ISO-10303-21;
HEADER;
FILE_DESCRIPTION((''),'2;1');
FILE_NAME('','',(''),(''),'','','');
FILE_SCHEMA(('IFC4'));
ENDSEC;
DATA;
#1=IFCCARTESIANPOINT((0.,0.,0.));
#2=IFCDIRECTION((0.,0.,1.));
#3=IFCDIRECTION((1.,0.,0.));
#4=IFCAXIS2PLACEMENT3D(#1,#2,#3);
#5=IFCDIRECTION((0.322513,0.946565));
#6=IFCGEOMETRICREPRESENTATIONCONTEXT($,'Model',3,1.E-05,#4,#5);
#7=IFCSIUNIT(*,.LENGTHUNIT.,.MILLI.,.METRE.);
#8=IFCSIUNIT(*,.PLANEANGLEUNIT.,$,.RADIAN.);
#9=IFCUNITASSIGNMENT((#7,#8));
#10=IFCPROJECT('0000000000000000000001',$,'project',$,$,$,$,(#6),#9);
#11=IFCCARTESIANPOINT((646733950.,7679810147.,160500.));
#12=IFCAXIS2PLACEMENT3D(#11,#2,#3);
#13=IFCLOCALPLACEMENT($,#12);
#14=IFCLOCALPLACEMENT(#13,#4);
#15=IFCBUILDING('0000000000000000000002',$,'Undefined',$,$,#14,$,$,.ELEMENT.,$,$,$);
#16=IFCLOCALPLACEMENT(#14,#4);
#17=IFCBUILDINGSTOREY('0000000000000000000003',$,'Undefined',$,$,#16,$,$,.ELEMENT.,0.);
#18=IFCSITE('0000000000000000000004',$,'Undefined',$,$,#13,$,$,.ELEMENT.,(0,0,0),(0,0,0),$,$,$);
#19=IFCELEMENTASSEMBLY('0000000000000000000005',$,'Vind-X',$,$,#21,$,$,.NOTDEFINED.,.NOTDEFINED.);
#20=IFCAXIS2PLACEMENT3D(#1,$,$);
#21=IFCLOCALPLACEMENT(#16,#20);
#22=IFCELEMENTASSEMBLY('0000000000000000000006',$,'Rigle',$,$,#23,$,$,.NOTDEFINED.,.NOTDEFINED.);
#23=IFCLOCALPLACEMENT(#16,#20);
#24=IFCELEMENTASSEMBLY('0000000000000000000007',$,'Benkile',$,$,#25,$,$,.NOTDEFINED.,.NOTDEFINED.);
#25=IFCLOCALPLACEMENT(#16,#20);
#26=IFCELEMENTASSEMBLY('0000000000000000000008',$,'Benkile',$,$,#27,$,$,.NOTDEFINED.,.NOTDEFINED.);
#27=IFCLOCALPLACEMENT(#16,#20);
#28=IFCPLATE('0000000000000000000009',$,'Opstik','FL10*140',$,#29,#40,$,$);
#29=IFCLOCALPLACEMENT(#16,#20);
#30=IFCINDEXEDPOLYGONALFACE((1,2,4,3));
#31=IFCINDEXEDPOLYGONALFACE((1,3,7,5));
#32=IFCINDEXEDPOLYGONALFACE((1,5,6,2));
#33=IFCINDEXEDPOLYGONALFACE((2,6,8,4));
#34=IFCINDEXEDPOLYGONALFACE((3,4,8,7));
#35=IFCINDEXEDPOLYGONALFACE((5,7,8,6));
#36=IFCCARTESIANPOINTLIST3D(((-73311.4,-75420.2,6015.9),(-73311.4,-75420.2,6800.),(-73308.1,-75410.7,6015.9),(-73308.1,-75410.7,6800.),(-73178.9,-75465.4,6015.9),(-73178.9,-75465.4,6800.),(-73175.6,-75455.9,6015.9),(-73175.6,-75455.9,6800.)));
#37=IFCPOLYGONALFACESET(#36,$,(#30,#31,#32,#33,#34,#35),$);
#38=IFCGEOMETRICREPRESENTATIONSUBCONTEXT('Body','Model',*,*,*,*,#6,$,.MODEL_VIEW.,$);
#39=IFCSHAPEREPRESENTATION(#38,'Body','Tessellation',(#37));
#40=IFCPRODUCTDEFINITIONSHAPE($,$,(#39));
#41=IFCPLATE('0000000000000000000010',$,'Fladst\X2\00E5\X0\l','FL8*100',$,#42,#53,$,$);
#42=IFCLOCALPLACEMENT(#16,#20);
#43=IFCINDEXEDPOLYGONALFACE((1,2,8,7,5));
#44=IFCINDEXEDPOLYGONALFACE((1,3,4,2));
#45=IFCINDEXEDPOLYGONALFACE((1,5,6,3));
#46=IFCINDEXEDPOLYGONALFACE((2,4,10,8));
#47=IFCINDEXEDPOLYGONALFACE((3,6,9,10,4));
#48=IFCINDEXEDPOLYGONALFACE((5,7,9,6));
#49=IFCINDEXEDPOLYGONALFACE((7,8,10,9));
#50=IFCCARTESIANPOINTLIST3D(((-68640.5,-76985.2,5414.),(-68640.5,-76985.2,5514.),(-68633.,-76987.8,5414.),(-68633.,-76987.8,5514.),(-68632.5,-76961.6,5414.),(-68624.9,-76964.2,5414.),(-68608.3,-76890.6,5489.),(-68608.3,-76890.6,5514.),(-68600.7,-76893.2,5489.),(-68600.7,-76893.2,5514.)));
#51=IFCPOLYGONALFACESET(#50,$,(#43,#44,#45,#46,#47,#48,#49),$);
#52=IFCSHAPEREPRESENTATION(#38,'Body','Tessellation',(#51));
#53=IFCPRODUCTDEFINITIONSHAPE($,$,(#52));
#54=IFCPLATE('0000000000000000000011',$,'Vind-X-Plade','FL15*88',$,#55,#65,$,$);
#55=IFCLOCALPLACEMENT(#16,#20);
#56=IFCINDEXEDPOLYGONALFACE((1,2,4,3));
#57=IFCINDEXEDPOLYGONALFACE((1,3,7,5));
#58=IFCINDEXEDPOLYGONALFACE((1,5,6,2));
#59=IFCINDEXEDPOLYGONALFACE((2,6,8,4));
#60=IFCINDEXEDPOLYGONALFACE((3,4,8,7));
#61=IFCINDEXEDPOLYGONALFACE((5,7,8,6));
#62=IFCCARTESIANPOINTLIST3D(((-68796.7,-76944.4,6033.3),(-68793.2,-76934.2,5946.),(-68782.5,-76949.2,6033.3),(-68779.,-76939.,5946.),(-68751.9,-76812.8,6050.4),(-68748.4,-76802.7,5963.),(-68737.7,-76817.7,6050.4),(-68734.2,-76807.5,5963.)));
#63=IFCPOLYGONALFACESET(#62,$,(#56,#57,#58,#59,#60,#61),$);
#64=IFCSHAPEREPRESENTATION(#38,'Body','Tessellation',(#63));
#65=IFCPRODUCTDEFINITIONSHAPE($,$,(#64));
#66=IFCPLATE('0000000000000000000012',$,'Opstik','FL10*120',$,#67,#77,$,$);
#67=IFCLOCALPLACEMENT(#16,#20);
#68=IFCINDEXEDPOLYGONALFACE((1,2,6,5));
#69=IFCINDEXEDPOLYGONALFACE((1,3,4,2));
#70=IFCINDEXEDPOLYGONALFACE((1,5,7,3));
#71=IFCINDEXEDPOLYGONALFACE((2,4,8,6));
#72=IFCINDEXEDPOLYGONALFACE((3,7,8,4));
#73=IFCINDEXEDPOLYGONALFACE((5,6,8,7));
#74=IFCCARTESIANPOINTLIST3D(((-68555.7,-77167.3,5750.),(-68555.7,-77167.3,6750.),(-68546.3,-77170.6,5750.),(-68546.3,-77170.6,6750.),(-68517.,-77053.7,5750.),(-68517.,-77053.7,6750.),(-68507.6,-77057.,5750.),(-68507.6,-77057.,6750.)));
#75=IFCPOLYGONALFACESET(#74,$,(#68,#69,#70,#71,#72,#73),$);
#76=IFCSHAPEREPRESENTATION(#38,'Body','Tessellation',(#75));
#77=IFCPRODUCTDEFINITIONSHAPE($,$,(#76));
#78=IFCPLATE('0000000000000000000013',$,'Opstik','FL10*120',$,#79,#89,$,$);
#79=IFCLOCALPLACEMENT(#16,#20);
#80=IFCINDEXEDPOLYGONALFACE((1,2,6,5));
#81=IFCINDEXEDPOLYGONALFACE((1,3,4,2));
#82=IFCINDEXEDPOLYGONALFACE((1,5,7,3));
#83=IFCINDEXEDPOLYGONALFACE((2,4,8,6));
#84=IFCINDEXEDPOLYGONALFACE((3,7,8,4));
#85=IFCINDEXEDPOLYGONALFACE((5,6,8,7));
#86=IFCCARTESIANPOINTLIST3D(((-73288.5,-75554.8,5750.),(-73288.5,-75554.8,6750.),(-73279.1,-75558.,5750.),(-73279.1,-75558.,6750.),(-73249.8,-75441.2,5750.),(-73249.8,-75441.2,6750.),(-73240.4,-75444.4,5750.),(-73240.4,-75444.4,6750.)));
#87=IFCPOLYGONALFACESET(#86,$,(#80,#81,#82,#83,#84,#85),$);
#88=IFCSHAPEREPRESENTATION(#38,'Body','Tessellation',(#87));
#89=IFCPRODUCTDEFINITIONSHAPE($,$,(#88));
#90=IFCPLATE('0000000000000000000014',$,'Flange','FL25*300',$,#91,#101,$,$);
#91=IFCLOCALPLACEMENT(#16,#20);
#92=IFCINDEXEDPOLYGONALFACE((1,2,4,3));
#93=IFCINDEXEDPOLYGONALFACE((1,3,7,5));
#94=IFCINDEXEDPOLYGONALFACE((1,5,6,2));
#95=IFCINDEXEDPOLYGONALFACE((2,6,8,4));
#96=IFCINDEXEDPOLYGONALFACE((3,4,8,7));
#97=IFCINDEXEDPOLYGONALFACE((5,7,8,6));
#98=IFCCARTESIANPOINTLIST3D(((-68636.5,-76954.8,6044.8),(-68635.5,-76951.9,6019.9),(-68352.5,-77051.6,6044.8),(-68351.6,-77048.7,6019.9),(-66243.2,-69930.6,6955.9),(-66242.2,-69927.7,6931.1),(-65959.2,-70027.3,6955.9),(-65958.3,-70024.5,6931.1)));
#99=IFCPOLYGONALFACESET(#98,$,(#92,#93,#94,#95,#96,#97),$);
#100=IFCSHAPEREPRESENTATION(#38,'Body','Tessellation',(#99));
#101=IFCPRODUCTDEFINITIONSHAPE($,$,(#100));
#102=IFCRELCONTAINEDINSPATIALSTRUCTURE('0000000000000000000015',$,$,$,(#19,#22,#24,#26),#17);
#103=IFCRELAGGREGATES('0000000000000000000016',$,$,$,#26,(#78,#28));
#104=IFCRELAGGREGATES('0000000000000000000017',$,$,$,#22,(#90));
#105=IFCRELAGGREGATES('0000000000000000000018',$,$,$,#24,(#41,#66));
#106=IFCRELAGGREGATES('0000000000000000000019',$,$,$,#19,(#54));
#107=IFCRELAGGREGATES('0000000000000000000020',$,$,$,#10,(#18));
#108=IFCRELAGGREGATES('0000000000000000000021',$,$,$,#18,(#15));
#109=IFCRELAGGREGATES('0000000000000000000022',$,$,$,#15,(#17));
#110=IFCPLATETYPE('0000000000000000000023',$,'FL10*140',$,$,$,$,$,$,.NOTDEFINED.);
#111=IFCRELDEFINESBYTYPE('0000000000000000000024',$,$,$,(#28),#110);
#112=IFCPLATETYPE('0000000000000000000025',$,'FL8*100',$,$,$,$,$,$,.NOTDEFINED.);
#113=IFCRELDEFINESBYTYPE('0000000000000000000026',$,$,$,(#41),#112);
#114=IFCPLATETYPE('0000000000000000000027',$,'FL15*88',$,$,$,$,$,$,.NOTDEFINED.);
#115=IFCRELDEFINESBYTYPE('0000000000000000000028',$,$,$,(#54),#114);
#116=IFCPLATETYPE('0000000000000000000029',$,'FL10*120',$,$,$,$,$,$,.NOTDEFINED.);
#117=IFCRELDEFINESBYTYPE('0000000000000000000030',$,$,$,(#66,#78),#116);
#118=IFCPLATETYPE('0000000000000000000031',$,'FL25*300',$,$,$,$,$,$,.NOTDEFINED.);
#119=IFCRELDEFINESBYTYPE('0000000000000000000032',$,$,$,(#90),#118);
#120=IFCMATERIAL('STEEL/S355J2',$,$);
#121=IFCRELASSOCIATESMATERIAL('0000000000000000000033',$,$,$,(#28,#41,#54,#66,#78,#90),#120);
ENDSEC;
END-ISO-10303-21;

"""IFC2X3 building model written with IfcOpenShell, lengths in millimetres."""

from ifc_helpers import new_model, si_unit, direction, frame, origin_with_axes, place, context, subcontext, project, spatial, polyline, outline, extrude, clip, halfspace, material, type_object, element, aggregate, save


model = new_model("IFC2X3")

# Units and contexts
model_context = context("Model", 3, precision=1e-05, world=origin_with_axes(), true_north=direction((0.322513, 0.946565)))
body_context = subcontext(model_context, "Body", "Model", "MODEL_VIEW")
ifc_project = project(units=[si_unit("LENGTHUNIT", "METRE", prefix="MILLI"), si_unit("PLANEANGLEUNIT", "RADIAN")], contexts=[model_context])

# Site, building, storey
site_placement = place(None, frame((646733950.0, 7679810147.0, 160500.0), z_axis=(0.0, 0.0, 1.0), x_axis=(1.0, 0.0, 0.0)))
site = spatial("IfcSite", under=ifc_project, at=site_placement, Name="Undefined", CompositionType="ELEMENT", RefLatitude=(0, 0, 0), RefLongitude=(0, 0, 0))
building_placement = place(site_placement, origin_with_axes())
building = spatial("IfcBuilding", under=site, at=building_placement, Name="Undefined", CompositionType="ELEMENT")
storey_placement = place(building_placement, origin_with_axes())
storey = spatial("IfcBuildingStorey", under=building, at=storey_placement, Name="Undefined", CompositionType="ELEMENT", Elevation=0.0)

# Element assembly
assembly_1_placement = place(storey_placement, origin_with_axes())
assembly_1 = element("IfcElementAssembly", 1, at=assembly_1_placement, inside=storey, Name="Vind-X", AssemblyPlace="NOTDEFINED", PredefinedType="NOTDEFINED")

# Element assemblies
assembly_2_placement = place(storey_placement, origin_with_axes())
assembly_2 = element("IfcElementAssembly", 2, at=assembly_2_placement, inside=storey, Name="Rigle", AssemblyPlace="NOTDEFINED", PredefinedType="NOTDEFINED")
ifc_material_1 = material(Name="STEEL/S355J2")
assembly_3_placement = place(storey_placement, origin_with_axes())
assembly_3 = element("IfcElementAssembly", 3, at=assembly_3_placement, inside=storey, Name="Benkile", AssemblyPlace="NOTDEFINED", PredefinedType="NOTDEFINED")
assembly_4_placement = place(storey_placement, origin_with_axes())
assembly_4 = element("IfcElementAssembly", 4, at=assembly_4_placement, inside=storey, Name="Benkile", AssemblyPlace="NOTDEFINED", PredefinedType="NOTDEFINED")

# Shared definitions
plate_type_1 = type_object("IfcPlateType", Name="FL10*140", PredefinedType="NOTDEFINED")

# Plates
plate_1_placement = place(assembly_4_placement, frame((-73177.2, -75460.6, 6015.9), z_axis=(-0.322513, -0.946565, 0.0), x_axis=(0.0, 0.0, 1.0)))
plate_1 = element("IfcPlate", 5, at=plate_1_placement, type_object=plate_type_1, material=ifc_material_1, Name="Opstik", Description="FL10*140", context=body_context, shape_type="SweptSolid", body=[
    extrude(outline(polyline([(0.0, 0.0), (784.1, 0.0), (784.1, 0.0), (784.1, 140.0), (784.1, 140.0), (0.0, 140.0), (0.0, 0.0)])), frame((0.0, 0.0, -5.0), z_axis=(0.0, 0.0, 1.0), x_axis=(1.0, 0.0, 0.0)), (0.0, 0.0, 1.0), 10.0),
])
plate_type_2 = type_object("IfcPlateType", Name="FL8*100", PredefinedType="NOTDEFINED")
plate_2_placement = place(assembly_3_placement, frame((-68604.5, -76891.9, 5514.0), z_axis=(0.946565, -0.322513, 0.0), x_axis=(-0.322513, -0.946565, 0.0)))
plate_2 = element("IfcPlate", 6, at=plate_2_placement, type_object=plate_type_2, material=ifc_material_1, Name="Fladstål", Description="FL8*100", context=body_context, shape_type="SweptSolid", body=[
    extrude(outline(polyline([(0.0, 0.0), (100.0, 0.0), (100.0, 100.0), (75.0, 100.0), (0.0, 25.0), (0.0, 0.0)])), frame((0.0, 0.0, -4.0), z_axis=(0.0, 0.0, 1.0), x_axis=(1.0, 0.0, 0.0)), (0.0, 0.0, 1.0), 8.0),
])
plate_type_3 = type_object("IfcPlateType", Name="FL15*88", PredefinedType="NOTDEFINED")
plate_3_placement = place(assembly_1_placement, frame((-68741.3, -76805.1, 5963.0), z_axis=(-0.946565, 0.322513, 0.0), x_axis=(-0.320109, -0.93951, -0.121869)))
plate_3 = element("IfcPlate", 7, at=plate_3_placement, type_object=plate_type_3, material=ifc_material_1, Name="Vind-X-Plade", Description="FL15*88", context=body_context, shape_type="SweptSolid", body=[
    extrude(outline(polyline([(0.0, 0.0), (140.0, 0.0), (140.0, 88.0), (0.0, 88.0), (0.0, 0.0)])), frame((0.0, 0.0, -7.5), z_axis=(0.0, 0.0, 1.0), x_axis=(1.0, 0.0, 0.0)), (0.0, 0.0, 1.0), 15.0),
])
plate_type_4 = type_object("IfcPlateType", Name="FL10*120", PredefinedType="NOTDEFINED")
plate_4_placement = place(assembly_3_placement, frame((-68512.3, -77055.4, 5750.0), z_axis=(0.946565, -0.322513, 0.0), x_axis=(0.0, 0.0, 1.0)))
plate_4 = element("IfcPlate", 8, at=plate_4_placement, type_object=plate_type_4, material=ifc_material_1, Name="Opstik", Description="FL10*120", context=body_context, shape_type="SweptSolid", body=[
    extrude(outline(polyline([(0.0, 0.0), (1000.0, 0.0), (1000.0, 120.0), (1000.0, 120.0), (0.0, 120.0), (0.0, 120.0), (0.0, 0.0)])), frame((0.0, 0.0, -5.0), z_axis=(0.0, 0.0, 1.0), x_axis=(1.0, 0.0, 0.0)), (0.0, 0.0, 1.0), 10.0),
])
plate_5_placement = place(assembly_4_placement, frame((-73245.1, -75442.8, 5750.0), z_axis=(0.946565, -0.322513, 0.0), x_axis=(0.0, 0.0, 1.0)))
plate_5 = element("IfcPlate", 9, at=plate_5_placement, type_object=plate_type_4, material=ifc_material_1, Name="Opstik", Description="FL10*120", context=body_context, shape_type="SweptSolid", body=[
    extrude(outline(polyline([(0.0, 0.0), (1000.0, 0.0), (1000.0, 120.0), (1000.0, 120.0), (0.0, 120.0), (0.0, 120.0), (0.0, 0.0)])), frame((0.0, 0.0, -5.0), z_axis=(0.0, 0.0, 1.0), x_axis=(1.0, 0.0, 0.0)), (0.0, 0.0, 1.0), 10.0),
])
aggregate(assembly_4, [plate_5, plate_1])
plate_type_5 = type_object("IfcPlateType", Name="FL25*300", PredefinedType="NOTDEFINED")
plate_6_placement = place(assembly_2_placement, frame((-68494.0, -77001.8, 6032.4), z_axis=(0.039304, 0.115357, -0.992546), x_axis=(0.320109, 0.93951, 0.121869)))
plate_6 = element("IfcPlate", 10, at=plate_6_placement, type_object=plate_type_5, material=ifc_material_1, Name="Flange", Description="FL25*300", context=body_context, shape_type="Clipping", body=[
    clip(extrude(outline(polyline([(0.0, -150.0), (0.0, 150.0), (7476.5, 150.0), (7476.5, -150.0), (0.0, -150.0)])), frame((0.0, 0.0, -12.5), z_axis=(0.0, 0.0, 1.0), x_axis=(1.0, 0.0, 0.0)), (0.0, 0.0, 1.0), 25.0), halfspace(frame((7476.5, 0.0, 287.5), z_axis=(1.0, 0.0, 0.0), x_axis=(0.0, 1.0, 0.0)), False)),
])
aggregate(assembly_2, [plate_6])

aggregate(assembly_3, [plate_2, plate_4])
aggregate(assembly_1, [plate_3])

save(model, "model.ifc")
